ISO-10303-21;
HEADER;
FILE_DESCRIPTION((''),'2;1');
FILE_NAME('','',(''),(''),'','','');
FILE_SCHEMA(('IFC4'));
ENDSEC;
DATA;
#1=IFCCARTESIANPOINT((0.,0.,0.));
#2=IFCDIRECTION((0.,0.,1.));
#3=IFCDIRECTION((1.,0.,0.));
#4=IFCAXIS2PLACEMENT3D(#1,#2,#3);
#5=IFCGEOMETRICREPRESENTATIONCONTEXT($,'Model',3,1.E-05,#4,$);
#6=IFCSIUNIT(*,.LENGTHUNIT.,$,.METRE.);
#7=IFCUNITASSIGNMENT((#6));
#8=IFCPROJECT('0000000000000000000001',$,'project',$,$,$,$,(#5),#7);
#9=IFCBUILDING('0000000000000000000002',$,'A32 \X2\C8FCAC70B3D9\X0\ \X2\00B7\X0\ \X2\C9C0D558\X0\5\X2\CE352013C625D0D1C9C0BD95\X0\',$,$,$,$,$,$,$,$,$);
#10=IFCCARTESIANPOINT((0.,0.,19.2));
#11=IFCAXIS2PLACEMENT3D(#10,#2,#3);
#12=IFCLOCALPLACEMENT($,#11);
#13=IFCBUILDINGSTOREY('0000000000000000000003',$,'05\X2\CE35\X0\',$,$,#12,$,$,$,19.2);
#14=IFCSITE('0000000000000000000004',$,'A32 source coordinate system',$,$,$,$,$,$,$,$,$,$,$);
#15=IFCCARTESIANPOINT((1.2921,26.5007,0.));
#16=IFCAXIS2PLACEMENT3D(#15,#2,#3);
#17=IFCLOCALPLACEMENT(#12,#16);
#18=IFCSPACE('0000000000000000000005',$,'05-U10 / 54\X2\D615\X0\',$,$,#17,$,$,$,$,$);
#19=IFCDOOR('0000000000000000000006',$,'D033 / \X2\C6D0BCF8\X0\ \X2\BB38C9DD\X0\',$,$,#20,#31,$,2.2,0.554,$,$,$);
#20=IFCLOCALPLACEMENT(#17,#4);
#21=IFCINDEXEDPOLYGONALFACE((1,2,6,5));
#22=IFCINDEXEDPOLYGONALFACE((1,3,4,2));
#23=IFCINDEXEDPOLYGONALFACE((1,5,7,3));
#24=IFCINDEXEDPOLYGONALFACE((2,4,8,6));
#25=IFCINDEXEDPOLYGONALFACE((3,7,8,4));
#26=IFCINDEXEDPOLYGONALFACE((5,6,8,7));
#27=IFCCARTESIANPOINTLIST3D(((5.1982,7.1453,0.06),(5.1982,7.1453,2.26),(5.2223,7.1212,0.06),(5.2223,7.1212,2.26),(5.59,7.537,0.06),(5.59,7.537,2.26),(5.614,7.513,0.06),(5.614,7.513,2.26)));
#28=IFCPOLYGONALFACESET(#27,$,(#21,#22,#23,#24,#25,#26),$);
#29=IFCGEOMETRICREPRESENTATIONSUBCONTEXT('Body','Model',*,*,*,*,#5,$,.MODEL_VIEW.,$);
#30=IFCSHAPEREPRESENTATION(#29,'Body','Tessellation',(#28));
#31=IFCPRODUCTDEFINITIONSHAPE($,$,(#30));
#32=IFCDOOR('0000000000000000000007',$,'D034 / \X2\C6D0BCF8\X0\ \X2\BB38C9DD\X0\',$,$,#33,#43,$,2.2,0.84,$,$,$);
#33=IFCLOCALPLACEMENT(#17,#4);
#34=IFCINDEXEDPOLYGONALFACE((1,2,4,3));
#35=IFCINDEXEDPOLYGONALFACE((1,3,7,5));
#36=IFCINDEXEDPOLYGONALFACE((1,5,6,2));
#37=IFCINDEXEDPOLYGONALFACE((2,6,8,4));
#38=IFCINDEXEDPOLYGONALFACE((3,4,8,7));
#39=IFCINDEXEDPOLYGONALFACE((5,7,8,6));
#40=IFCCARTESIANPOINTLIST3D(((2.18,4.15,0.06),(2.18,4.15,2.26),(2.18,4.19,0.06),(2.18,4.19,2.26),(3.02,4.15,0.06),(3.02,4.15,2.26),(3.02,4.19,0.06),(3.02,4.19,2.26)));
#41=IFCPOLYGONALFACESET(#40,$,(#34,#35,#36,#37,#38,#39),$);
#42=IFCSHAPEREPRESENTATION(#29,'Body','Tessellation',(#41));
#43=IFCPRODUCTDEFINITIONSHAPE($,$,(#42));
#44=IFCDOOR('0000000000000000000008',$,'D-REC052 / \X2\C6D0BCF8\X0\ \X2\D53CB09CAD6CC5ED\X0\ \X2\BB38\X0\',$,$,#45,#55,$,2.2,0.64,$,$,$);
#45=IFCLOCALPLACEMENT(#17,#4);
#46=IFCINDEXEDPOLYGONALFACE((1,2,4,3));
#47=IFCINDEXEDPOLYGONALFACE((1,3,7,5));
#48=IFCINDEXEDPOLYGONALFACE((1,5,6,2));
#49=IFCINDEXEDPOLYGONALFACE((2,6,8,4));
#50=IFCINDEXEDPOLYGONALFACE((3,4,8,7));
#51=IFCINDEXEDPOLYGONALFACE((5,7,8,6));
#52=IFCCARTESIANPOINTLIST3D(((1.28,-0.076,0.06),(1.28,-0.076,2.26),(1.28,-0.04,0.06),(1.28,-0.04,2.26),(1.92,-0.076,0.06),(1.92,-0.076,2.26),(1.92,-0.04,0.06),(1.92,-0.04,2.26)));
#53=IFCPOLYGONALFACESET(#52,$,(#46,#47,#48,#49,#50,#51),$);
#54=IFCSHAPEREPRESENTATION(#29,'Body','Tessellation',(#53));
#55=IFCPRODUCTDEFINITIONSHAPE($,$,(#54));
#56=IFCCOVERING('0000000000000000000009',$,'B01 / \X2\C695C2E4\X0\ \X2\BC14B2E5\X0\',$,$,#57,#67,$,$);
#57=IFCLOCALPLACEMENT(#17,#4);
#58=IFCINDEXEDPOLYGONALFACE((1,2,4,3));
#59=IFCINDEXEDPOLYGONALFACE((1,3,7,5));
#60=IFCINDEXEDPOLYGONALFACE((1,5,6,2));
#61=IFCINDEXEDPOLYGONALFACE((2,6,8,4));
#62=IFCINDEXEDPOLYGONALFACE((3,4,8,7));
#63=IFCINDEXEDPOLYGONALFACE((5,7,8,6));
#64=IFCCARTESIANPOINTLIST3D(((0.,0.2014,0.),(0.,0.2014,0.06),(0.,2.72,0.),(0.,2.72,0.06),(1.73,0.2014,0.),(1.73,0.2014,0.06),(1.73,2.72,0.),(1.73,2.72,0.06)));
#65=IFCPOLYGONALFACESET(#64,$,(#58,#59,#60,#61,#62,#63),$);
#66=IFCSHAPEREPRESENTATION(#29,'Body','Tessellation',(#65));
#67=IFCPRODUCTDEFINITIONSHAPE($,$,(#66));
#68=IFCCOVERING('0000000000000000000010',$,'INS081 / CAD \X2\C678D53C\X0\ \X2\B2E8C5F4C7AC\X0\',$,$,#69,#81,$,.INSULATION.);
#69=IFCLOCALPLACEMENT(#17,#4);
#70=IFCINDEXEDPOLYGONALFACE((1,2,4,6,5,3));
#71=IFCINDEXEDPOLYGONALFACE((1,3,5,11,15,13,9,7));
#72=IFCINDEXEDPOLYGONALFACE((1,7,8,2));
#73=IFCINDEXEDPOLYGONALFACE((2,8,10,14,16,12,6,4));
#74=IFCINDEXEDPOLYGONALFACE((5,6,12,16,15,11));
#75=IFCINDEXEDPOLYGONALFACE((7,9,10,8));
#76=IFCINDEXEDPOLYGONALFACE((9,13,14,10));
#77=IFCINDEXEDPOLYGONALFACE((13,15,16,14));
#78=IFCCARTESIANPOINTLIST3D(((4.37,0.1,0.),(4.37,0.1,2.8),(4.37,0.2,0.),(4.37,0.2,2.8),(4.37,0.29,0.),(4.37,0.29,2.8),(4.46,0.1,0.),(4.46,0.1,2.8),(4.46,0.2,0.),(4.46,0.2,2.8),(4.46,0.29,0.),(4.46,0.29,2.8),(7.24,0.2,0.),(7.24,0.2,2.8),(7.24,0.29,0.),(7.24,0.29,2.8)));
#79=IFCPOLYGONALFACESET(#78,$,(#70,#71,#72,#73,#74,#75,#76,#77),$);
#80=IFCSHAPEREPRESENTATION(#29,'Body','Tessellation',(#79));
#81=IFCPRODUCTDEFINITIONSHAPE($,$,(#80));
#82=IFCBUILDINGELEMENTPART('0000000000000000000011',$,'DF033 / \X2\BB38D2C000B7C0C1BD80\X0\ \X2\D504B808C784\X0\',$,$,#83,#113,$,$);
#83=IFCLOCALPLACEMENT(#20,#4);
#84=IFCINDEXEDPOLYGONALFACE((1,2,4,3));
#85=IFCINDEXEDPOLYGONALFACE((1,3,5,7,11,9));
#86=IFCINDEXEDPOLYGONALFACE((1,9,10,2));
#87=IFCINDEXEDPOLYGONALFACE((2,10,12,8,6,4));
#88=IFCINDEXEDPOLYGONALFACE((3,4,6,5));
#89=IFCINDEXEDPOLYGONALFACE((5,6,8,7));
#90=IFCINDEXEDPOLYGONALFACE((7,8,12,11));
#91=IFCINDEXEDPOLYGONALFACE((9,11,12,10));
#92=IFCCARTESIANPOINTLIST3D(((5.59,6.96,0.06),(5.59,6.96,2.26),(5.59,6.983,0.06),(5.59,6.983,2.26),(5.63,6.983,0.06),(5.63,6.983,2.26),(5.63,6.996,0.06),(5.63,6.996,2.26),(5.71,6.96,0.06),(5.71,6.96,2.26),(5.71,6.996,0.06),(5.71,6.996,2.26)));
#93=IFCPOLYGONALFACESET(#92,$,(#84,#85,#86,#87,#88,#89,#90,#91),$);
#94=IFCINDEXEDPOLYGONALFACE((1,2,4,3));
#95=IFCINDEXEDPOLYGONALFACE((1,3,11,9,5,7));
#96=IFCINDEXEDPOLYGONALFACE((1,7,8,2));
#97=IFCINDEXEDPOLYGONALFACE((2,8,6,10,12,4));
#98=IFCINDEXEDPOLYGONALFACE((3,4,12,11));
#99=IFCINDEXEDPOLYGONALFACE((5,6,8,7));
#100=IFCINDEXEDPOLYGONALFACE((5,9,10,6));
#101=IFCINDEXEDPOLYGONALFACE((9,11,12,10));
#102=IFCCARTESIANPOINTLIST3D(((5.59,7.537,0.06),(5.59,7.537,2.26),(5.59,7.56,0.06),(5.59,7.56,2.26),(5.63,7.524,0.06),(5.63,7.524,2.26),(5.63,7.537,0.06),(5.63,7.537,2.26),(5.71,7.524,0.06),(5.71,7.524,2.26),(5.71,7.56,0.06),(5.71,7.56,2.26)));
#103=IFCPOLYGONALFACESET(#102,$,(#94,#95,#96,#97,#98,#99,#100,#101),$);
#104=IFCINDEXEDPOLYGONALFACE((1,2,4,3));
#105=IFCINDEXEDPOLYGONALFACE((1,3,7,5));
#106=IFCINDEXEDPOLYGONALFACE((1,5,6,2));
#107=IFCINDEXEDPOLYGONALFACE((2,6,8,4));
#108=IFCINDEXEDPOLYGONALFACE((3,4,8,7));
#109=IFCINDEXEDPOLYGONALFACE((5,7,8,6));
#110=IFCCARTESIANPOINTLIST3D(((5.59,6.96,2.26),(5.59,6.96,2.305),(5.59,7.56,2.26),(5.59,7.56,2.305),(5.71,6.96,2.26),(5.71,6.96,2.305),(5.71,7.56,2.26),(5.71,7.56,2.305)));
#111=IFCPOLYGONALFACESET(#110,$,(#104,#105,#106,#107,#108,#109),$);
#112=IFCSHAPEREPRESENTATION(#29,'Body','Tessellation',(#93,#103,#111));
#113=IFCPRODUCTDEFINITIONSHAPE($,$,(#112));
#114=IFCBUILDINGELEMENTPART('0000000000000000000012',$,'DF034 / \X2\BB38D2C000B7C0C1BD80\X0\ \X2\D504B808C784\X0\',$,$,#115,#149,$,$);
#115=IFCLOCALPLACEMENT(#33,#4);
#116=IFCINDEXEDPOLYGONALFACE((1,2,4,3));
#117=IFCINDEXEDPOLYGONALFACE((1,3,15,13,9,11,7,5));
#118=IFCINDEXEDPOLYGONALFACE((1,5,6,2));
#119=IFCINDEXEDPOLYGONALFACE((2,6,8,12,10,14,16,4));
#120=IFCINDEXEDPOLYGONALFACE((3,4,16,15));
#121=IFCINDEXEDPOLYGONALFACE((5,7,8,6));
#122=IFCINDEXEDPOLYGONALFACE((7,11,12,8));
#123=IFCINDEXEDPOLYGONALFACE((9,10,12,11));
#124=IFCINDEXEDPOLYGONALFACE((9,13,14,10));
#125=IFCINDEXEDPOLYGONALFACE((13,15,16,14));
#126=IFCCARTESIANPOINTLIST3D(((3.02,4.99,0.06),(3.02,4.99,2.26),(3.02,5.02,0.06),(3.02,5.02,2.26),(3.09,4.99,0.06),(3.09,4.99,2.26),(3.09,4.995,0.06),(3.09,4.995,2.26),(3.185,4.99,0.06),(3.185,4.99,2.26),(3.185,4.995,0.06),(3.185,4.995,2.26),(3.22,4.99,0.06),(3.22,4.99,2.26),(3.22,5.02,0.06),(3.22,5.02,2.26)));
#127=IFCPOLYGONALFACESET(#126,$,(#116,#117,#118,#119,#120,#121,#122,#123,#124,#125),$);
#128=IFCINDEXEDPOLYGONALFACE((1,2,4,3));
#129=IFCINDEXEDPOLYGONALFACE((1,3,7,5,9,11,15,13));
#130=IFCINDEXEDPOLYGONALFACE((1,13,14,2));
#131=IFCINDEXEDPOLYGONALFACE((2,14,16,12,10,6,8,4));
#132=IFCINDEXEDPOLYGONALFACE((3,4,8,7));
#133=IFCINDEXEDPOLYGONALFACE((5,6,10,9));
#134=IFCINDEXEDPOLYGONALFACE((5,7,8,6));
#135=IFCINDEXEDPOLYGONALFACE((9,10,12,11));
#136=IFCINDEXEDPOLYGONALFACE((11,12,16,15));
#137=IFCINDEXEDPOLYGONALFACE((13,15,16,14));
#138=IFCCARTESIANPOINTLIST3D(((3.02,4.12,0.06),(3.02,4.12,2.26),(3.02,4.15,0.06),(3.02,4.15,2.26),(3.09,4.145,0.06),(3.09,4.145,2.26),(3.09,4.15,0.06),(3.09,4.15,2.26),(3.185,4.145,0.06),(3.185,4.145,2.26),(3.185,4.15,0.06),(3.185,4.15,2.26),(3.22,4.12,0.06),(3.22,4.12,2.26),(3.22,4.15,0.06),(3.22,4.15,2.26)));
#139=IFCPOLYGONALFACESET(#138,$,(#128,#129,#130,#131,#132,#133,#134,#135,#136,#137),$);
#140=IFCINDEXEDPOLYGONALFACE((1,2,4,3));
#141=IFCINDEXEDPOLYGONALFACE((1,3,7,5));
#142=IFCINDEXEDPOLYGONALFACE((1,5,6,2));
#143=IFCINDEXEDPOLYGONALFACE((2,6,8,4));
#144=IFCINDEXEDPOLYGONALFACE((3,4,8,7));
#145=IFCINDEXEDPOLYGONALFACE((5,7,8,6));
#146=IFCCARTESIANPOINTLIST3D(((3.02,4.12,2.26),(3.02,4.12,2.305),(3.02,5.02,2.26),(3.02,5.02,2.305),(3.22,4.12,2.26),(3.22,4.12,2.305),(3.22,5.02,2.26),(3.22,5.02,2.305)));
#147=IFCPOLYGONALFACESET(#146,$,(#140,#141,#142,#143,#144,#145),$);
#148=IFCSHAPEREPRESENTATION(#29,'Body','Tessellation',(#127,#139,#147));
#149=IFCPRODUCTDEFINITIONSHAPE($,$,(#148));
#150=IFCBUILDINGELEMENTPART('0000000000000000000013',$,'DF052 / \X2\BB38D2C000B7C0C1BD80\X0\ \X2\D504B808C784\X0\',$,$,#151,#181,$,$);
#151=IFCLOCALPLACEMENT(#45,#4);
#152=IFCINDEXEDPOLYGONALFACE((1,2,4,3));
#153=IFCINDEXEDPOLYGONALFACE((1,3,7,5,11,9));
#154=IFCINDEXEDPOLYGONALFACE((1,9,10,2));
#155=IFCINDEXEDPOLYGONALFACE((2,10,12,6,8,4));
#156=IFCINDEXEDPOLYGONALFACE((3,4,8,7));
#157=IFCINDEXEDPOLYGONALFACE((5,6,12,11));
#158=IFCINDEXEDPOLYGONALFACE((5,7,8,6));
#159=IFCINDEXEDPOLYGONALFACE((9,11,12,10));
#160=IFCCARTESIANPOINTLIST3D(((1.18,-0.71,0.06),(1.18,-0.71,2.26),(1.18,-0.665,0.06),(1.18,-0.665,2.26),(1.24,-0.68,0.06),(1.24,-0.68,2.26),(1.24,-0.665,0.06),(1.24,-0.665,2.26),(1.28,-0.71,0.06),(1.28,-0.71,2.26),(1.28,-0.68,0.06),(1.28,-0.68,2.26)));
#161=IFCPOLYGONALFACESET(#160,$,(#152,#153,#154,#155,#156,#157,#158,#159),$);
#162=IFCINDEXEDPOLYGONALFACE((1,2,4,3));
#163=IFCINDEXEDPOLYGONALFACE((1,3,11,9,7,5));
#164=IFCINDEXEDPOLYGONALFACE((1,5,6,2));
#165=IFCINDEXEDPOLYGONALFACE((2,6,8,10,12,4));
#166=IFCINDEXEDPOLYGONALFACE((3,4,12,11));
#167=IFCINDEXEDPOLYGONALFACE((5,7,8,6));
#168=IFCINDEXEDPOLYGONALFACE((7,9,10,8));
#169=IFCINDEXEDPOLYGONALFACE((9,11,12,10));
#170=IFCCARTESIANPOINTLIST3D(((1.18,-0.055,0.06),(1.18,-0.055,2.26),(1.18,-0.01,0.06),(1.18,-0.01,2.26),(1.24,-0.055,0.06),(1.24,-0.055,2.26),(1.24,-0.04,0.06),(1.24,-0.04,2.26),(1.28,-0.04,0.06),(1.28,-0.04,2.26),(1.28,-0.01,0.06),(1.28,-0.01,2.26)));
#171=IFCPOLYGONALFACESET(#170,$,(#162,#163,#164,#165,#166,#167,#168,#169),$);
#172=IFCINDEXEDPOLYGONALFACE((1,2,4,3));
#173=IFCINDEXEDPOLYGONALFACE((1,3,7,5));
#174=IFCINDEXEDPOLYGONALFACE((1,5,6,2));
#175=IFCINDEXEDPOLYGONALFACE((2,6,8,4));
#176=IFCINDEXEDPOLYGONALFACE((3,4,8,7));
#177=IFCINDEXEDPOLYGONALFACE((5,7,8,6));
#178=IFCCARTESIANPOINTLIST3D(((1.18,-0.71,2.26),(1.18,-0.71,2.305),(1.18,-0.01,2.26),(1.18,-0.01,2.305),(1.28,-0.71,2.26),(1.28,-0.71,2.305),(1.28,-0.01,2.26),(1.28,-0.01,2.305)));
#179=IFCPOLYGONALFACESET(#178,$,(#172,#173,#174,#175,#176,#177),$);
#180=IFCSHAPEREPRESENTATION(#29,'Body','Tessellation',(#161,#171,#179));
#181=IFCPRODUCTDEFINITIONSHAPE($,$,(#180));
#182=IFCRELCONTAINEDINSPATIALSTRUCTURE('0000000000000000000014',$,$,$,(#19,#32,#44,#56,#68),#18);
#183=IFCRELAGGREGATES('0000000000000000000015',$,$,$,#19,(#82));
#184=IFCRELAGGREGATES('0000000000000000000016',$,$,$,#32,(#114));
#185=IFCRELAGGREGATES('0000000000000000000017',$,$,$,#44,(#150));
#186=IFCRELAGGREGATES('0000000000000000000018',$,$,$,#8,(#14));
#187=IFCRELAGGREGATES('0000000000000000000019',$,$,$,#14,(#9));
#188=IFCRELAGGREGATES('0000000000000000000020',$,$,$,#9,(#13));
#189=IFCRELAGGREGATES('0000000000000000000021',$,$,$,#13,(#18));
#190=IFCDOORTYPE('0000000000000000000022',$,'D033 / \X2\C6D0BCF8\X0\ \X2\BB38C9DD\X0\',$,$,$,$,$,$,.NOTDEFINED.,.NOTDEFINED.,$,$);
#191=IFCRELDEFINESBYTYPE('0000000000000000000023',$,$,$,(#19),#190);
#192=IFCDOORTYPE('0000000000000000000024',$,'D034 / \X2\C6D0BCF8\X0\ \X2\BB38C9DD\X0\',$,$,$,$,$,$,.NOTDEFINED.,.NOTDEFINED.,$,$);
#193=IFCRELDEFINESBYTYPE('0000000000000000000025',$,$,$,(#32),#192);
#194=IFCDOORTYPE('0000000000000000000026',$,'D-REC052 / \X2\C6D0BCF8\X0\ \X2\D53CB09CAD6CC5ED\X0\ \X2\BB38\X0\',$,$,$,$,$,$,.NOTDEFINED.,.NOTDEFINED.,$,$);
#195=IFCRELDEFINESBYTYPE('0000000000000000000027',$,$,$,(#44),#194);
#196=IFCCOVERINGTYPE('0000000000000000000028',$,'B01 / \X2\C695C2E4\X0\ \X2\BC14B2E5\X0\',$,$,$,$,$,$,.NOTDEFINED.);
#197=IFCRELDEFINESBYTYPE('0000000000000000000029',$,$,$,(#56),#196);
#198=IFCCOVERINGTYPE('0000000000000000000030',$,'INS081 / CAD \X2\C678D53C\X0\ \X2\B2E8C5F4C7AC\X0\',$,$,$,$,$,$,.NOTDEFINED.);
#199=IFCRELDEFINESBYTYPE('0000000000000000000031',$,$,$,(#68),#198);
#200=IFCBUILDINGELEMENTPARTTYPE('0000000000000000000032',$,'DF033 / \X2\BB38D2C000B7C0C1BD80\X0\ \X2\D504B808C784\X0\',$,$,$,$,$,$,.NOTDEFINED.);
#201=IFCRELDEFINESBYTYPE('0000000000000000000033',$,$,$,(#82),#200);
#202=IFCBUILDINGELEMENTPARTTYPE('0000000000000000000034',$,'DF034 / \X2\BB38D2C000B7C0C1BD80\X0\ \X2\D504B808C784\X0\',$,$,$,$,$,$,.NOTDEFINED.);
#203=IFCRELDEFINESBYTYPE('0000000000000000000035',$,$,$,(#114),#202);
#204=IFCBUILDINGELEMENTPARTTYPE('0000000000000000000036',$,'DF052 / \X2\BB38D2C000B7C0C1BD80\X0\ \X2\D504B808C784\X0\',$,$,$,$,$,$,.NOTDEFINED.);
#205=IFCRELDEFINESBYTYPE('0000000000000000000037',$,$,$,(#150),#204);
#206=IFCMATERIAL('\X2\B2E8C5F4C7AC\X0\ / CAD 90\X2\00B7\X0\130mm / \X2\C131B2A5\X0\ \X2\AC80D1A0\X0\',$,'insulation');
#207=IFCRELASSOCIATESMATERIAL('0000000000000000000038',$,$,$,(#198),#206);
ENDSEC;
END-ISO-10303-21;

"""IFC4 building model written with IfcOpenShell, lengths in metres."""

from ifc_helpers import new_model, si_unit, frame, origin, origin_with_axes, place, context, subcontext, project, spatial, polyline, outline, extrude, source, transform, mapped, material, type_object, type_shapes, element, aggregate, save


model = new_model("IFC4")

# Units and contexts
model_context = context("Model", 3, precision=1e-05, world=origin_with_axes())
body_context = subcontext(model_context, "Body", "Model", "MODEL_VIEW")
ifc_project = project(units=[si_unit("LENGTHUNIT", "METRE")], contexts=[model_context])

# Site, building, storey, space
storey_placement = place(None, frame((0.0, 0.0, 19.2), z_axis=(0.0, 0.0, 1.0), x_axis=(1.0, 0.0, 0.0)))
space_placement = place(storey_placement, frame((1.2921, 26.5007, 0.0), z_axis=(0.0, 0.0, 1.0), x_axis=(1.0, 0.0, 0.0)))
site = spatial("IfcSite", under=ifc_project, Name="A32 source coordinate system")
building = spatial("IfcBuilding", under=site, Name="A32 주거동 · 지하5층–옥탑지붕")
storey = spatial("IfcBuildingStorey", under=building, at=storey_placement, Name="05층", Elevation=19.2)
space = spatial("IfcSpace", under=storey, at=space_placement, Name="05-U10 / 54형")

# Doors
door_type_1 = type_object("IfcDoorType", Name="D033 / 원본 문짝", OperationType="NOTDEFINED", PredefinedType="NOTDEFINED")
shared_shape_1 = source(origin(), body_context, "Body", "SweptSolid", [
    extrude(outline(polyline([(5.2223, 7.1212), (5.1982, 7.1453), (5.59, 7.537), (5.614, 7.513), (5.2223, 7.1212)])), frame((0.0, 0.0, 0.06)), (0.0, 0.0, 1.0), 2.2),
])
type_shapes(door_type_1, [shared_shape_1])
door_1_placement = place(space_placement, origin_with_axes())
door_1 = element("IfcDoor", 1, at=door_1_placement, inside=space, type_object=door_type_1, Name="D033 / 원본 문짝", OverallHeight=2.2, OverallWidth=0.554, context=body_context, shape_type="MappedRepresentation", body=[
    mapped(shared_shape_1, transform((0.0, 0.0, 0.0), scale=1.0)),
])
door_type_2 = type_object("IfcDoorType", Name="D034 / 원본 문짝", OperationType="NOTDEFINED", PredefinedType="NOTDEFINED")
shared_shape_2 = source(origin(), body_context, "Body", "SweptSolid", [
    extrude(outline(polyline([(3.02, 4.15), (2.18, 4.15), (2.18, 4.19), (3.02, 4.19), (3.02, 4.15)])), frame((0.0, 0.0, 0.06)), (0.0, 0.0, 1.0), 2.2),
])
type_shapes(door_type_2, [shared_shape_2])
door_2_placement = place(space_placement, origin_with_axes())
door_2 = element("IfcDoor", 2, at=door_2_placement, inside=space, type_object=door_type_2, Name="D034 / 원본 문짝", OverallHeight=2.2, OverallWidth=0.84, context=body_context, shape_type="MappedRepresentation", body=[
    mapped(shared_shape_2, transform((0.0, 0.0, 0.0), scale=1.0)),
])
door_type_3 = type_object("IfcDoorType", Name="D-REC052 / 원본 피난구역 문", OperationType="NOTDEFINED", PredefinedType="NOTDEFINED")
shared_shape_3 = source(origin(), body_context, "Body", "SweptSolid", [
    extrude(outline(polyline([(1.92, -0.076), (1.28, -0.076), (1.28, -0.04), (1.92, -0.04), (1.92, -0.076)])), frame((0.0, 0.0, 0.06)), (0.0, 0.0, 1.0), 2.2),
])
type_shapes(door_type_3, [shared_shape_3])
door_3_placement = place(space_placement, origin_with_axes())
door_3 = element("IfcDoor", 3, at=door_3_placement, inside=space, type_object=door_type_3, Name="D-REC052 / 원본 피난구역 문", OverallHeight=2.2, OverallWidth=0.64, context=body_context, shape_type="MappedRepresentation", body=[
    mapped(shared_shape_3, transform((0.0, 0.0, 0.0), scale=1.0)),
])

# Coverings
covering_type_1 = type_object("IfcCoveringType", Name="B01 / 욕실 바닥", PredefinedType="NOTDEFINED")
shared_shape_4 = source(origin(), body_context, "Body", "SweptSolid", [
    extrude(outline(polyline([(0.0, 0.2014), (0.0, 2.72), (1.73, 2.72), (1.73, 0.2014), (0.0, 0.2014)])), origin(), (0.0, 0.0, 1.0), 0.06),
])
type_shapes(covering_type_1, [shared_shape_4])
covering_1_placement = place(space_placement, origin_with_axes())
element("IfcCovering", 4, at=covering_1_placement, inside=space, type_object=covering_type_1, Name="B01 / 욕실 바닥", context=body_context, shape_type="MappedRepresentation", body=[
    mapped(shared_shape_4, transform((0.0, 0.0, 0.0), scale=1.0)),
])
ifc_material = material(Name="단열재 / CAD 90·130mm / 성능 검토", Category="insulation")
covering_type_2 = type_object("IfcCoveringType", Name="INS081 / CAD 외피 단열재", PredefinedType="NOTDEFINED", material=ifc_material)
shared_shape_5 = source(origin(), body_context, "Body", "SweptSolid", [
    extrude(outline(polyline([(4.37, 0.2), (4.37, 0.29), (4.46, 0.29), (7.24, 0.29), (7.24, 0.2), (4.46, 0.2), (4.46, 0.1), (4.37, 0.1), (4.37, 0.2)])), origin(), (0.0, 0.0, 1.0), 2.8),
])
type_shapes(covering_type_2, [shared_shape_5])
covering_2_placement = place(space_placement, origin_with_axes())
element("IfcCovering", 5, at=covering_2_placement, inside=space, type_object=covering_type_2, Name="INS081 / CAD 외피 단열재", PredefinedType="INSULATION", context=body_context, shape_type="MappedRepresentation", body=[
    mapped(shared_shape_5, transform((0.0, 0.0, 0.0), scale=1.0)),
])

# Building element parts
building_element_part_type_1 = type_object("IfcBuildingElementPartType", Name="DF033 / 문틀·상부 프레임", PredefinedType="NOTDEFINED")
shared_shape_6 = source(origin(), body_context, "Body", "SweptSolid", [
    extrude(outline(polyline([(5.59, 6.96), (5.59, 6.983), (5.63, 6.983), (5.63, 6.996), (5.71, 6.996), (5.71, 6.96), (5.59, 6.96)])), frame((0.0, 0.0, 0.06)), (0.0, 0.0, 1.0), 2.2),
    extrude(outline(polyline([(5.71, 7.524), (5.63, 7.524), (5.63, 7.537), (5.59, 7.537), (5.59, 7.56), (5.71, 7.56), (5.71, 7.524)])), frame((0.0, 0.0, 0.06)), (0.0, 0.0, 1.0), 2.2),
    extrude(outline(polyline([(5.59, 6.96), (5.59, 7.56), (5.71, 7.56), (5.71, 6.96), (5.59, 6.96)])), frame((0.0, 0.0, 2.26)), (0.0, 0.0, 1.0), 0.045),
])
type_shapes(building_element_part_type_1, [shared_shape_6])
building_element_part_1_placement = place(door_1_placement, origin_with_axes())
building_element_part_1 = element("IfcBuildingElementPart", 6, at=building_element_part_1_placement, type_object=building_element_part_type_1, Name="DF033 / 문틀·상부 프레임", context=body_context, shape_type="MappedRepresentation", body=[
    mapped(shared_shape_6, transform((0.0, 0.0, 0.0), scale=1.0)),
])
aggregate(door_1, [building_element_part_1])
building_element_part_type_2 = type_object("IfcBuildingElementPartType", Name="DF034 / 문틀·상부 프레임", PredefinedType="NOTDEFINED")
shared_shape_7 = source(origin(), body_context, "Body", "SweptSolid", [
    extrude(outline(polyline([(3.22, 5.02), (3.22, 4.99), (3.185, 4.99), (3.185, 4.995), (3.09, 4.995), (3.09, 4.99), (3.02, 4.99), (3.02, 5.02), (3.22, 5.02)])), frame((0.0, 0.0, 0.06)), (0.0, 0.0, 1.0), 2.2),
    extrude(outline(polyline([(3.02, 4.15), (3.09, 4.15), (3.09, 4.145), (3.185, 4.145), (3.185, 4.15), (3.22, 4.15), (3.22, 4.12), (3.02, 4.12), (3.02, 4.15)])), frame((0.0, 0.0, 0.06)), (0.0, 0.0, 1.0), 2.2),
    extrude(outline(polyline([(3.02, 4.12), (3.02, 5.02), (3.22, 5.02), (3.22, 4.12), (3.02, 4.12)])), frame((0.0, 0.0, 2.26)), (0.0, 0.0, 1.0), 0.045),
])
type_shapes(building_element_part_type_2, [shared_shape_7])
building_element_part_2_placement = place(door_2_placement, origin_with_axes())
building_element_part_2 = element("IfcBuildingElementPart", 7, at=building_element_part_2_placement, type_object=building_element_part_type_2, Name="DF034 / 문틀·상부 프레임", context=body_context, shape_type="MappedRepresentation", body=[
    mapped(shared_shape_7, transform((0.0, 0.0, 0.0), scale=1.0)),
])
aggregate(door_2, [building_element_part_2])
building_element_part_type_3 = type_object("IfcBuildingElementPartType", Name="DF052 / 문틀·상부 프레임", PredefinedType="NOTDEFINED")
shared_shape_8 = source(origin(), body_context, "Body", "SweptSolid", [
    extrude(outline(polyline([(1.18, -0.71), (1.18, -0.665), (1.24, -0.665), (1.24, -0.68), (1.28, -0.68), (1.28, -0.71), (1.18, -0.71)])), frame((0.0, 0.0, 0.06)), (0.0, 0.0, 1.0), 2.2),
    extrude(outline(polyline([(1.28, -0.04), (1.24, -0.04), (1.24, -0.055), (1.18, -0.055), (1.18, -0.01), (1.28, -0.01), (1.28, -0.04)])), frame((0.0, 0.0, 0.06)), (0.0, 0.0, 1.0), 2.2),
    extrude(outline(polyline([(1.18, -0.71), (1.18, -0.01), (1.28, -0.01), (1.28, -0.71), (1.18, -0.71)])), frame((0.0, 0.0, 2.26)), (0.0, 0.0, 1.0), 0.045),
])
type_shapes(building_element_part_type_3, [shared_shape_8])
building_element_part_3_placement = place(door_3_placement, origin_with_axes())
building_element_part_3 = element("IfcBuildingElementPart", 8, at=building_element_part_3_placement, type_object=building_element_part_type_3, Name="DF052 / 문틀·상부 프레임", context=body_context, shape_type="MappedRepresentation", body=[
    mapped(shared_shape_8, transform((0.0, 0.0, 0.0), scale=1.0)),
])
aggregate(door_3, [building_element_part_3])

save(model, "model.ifc")
